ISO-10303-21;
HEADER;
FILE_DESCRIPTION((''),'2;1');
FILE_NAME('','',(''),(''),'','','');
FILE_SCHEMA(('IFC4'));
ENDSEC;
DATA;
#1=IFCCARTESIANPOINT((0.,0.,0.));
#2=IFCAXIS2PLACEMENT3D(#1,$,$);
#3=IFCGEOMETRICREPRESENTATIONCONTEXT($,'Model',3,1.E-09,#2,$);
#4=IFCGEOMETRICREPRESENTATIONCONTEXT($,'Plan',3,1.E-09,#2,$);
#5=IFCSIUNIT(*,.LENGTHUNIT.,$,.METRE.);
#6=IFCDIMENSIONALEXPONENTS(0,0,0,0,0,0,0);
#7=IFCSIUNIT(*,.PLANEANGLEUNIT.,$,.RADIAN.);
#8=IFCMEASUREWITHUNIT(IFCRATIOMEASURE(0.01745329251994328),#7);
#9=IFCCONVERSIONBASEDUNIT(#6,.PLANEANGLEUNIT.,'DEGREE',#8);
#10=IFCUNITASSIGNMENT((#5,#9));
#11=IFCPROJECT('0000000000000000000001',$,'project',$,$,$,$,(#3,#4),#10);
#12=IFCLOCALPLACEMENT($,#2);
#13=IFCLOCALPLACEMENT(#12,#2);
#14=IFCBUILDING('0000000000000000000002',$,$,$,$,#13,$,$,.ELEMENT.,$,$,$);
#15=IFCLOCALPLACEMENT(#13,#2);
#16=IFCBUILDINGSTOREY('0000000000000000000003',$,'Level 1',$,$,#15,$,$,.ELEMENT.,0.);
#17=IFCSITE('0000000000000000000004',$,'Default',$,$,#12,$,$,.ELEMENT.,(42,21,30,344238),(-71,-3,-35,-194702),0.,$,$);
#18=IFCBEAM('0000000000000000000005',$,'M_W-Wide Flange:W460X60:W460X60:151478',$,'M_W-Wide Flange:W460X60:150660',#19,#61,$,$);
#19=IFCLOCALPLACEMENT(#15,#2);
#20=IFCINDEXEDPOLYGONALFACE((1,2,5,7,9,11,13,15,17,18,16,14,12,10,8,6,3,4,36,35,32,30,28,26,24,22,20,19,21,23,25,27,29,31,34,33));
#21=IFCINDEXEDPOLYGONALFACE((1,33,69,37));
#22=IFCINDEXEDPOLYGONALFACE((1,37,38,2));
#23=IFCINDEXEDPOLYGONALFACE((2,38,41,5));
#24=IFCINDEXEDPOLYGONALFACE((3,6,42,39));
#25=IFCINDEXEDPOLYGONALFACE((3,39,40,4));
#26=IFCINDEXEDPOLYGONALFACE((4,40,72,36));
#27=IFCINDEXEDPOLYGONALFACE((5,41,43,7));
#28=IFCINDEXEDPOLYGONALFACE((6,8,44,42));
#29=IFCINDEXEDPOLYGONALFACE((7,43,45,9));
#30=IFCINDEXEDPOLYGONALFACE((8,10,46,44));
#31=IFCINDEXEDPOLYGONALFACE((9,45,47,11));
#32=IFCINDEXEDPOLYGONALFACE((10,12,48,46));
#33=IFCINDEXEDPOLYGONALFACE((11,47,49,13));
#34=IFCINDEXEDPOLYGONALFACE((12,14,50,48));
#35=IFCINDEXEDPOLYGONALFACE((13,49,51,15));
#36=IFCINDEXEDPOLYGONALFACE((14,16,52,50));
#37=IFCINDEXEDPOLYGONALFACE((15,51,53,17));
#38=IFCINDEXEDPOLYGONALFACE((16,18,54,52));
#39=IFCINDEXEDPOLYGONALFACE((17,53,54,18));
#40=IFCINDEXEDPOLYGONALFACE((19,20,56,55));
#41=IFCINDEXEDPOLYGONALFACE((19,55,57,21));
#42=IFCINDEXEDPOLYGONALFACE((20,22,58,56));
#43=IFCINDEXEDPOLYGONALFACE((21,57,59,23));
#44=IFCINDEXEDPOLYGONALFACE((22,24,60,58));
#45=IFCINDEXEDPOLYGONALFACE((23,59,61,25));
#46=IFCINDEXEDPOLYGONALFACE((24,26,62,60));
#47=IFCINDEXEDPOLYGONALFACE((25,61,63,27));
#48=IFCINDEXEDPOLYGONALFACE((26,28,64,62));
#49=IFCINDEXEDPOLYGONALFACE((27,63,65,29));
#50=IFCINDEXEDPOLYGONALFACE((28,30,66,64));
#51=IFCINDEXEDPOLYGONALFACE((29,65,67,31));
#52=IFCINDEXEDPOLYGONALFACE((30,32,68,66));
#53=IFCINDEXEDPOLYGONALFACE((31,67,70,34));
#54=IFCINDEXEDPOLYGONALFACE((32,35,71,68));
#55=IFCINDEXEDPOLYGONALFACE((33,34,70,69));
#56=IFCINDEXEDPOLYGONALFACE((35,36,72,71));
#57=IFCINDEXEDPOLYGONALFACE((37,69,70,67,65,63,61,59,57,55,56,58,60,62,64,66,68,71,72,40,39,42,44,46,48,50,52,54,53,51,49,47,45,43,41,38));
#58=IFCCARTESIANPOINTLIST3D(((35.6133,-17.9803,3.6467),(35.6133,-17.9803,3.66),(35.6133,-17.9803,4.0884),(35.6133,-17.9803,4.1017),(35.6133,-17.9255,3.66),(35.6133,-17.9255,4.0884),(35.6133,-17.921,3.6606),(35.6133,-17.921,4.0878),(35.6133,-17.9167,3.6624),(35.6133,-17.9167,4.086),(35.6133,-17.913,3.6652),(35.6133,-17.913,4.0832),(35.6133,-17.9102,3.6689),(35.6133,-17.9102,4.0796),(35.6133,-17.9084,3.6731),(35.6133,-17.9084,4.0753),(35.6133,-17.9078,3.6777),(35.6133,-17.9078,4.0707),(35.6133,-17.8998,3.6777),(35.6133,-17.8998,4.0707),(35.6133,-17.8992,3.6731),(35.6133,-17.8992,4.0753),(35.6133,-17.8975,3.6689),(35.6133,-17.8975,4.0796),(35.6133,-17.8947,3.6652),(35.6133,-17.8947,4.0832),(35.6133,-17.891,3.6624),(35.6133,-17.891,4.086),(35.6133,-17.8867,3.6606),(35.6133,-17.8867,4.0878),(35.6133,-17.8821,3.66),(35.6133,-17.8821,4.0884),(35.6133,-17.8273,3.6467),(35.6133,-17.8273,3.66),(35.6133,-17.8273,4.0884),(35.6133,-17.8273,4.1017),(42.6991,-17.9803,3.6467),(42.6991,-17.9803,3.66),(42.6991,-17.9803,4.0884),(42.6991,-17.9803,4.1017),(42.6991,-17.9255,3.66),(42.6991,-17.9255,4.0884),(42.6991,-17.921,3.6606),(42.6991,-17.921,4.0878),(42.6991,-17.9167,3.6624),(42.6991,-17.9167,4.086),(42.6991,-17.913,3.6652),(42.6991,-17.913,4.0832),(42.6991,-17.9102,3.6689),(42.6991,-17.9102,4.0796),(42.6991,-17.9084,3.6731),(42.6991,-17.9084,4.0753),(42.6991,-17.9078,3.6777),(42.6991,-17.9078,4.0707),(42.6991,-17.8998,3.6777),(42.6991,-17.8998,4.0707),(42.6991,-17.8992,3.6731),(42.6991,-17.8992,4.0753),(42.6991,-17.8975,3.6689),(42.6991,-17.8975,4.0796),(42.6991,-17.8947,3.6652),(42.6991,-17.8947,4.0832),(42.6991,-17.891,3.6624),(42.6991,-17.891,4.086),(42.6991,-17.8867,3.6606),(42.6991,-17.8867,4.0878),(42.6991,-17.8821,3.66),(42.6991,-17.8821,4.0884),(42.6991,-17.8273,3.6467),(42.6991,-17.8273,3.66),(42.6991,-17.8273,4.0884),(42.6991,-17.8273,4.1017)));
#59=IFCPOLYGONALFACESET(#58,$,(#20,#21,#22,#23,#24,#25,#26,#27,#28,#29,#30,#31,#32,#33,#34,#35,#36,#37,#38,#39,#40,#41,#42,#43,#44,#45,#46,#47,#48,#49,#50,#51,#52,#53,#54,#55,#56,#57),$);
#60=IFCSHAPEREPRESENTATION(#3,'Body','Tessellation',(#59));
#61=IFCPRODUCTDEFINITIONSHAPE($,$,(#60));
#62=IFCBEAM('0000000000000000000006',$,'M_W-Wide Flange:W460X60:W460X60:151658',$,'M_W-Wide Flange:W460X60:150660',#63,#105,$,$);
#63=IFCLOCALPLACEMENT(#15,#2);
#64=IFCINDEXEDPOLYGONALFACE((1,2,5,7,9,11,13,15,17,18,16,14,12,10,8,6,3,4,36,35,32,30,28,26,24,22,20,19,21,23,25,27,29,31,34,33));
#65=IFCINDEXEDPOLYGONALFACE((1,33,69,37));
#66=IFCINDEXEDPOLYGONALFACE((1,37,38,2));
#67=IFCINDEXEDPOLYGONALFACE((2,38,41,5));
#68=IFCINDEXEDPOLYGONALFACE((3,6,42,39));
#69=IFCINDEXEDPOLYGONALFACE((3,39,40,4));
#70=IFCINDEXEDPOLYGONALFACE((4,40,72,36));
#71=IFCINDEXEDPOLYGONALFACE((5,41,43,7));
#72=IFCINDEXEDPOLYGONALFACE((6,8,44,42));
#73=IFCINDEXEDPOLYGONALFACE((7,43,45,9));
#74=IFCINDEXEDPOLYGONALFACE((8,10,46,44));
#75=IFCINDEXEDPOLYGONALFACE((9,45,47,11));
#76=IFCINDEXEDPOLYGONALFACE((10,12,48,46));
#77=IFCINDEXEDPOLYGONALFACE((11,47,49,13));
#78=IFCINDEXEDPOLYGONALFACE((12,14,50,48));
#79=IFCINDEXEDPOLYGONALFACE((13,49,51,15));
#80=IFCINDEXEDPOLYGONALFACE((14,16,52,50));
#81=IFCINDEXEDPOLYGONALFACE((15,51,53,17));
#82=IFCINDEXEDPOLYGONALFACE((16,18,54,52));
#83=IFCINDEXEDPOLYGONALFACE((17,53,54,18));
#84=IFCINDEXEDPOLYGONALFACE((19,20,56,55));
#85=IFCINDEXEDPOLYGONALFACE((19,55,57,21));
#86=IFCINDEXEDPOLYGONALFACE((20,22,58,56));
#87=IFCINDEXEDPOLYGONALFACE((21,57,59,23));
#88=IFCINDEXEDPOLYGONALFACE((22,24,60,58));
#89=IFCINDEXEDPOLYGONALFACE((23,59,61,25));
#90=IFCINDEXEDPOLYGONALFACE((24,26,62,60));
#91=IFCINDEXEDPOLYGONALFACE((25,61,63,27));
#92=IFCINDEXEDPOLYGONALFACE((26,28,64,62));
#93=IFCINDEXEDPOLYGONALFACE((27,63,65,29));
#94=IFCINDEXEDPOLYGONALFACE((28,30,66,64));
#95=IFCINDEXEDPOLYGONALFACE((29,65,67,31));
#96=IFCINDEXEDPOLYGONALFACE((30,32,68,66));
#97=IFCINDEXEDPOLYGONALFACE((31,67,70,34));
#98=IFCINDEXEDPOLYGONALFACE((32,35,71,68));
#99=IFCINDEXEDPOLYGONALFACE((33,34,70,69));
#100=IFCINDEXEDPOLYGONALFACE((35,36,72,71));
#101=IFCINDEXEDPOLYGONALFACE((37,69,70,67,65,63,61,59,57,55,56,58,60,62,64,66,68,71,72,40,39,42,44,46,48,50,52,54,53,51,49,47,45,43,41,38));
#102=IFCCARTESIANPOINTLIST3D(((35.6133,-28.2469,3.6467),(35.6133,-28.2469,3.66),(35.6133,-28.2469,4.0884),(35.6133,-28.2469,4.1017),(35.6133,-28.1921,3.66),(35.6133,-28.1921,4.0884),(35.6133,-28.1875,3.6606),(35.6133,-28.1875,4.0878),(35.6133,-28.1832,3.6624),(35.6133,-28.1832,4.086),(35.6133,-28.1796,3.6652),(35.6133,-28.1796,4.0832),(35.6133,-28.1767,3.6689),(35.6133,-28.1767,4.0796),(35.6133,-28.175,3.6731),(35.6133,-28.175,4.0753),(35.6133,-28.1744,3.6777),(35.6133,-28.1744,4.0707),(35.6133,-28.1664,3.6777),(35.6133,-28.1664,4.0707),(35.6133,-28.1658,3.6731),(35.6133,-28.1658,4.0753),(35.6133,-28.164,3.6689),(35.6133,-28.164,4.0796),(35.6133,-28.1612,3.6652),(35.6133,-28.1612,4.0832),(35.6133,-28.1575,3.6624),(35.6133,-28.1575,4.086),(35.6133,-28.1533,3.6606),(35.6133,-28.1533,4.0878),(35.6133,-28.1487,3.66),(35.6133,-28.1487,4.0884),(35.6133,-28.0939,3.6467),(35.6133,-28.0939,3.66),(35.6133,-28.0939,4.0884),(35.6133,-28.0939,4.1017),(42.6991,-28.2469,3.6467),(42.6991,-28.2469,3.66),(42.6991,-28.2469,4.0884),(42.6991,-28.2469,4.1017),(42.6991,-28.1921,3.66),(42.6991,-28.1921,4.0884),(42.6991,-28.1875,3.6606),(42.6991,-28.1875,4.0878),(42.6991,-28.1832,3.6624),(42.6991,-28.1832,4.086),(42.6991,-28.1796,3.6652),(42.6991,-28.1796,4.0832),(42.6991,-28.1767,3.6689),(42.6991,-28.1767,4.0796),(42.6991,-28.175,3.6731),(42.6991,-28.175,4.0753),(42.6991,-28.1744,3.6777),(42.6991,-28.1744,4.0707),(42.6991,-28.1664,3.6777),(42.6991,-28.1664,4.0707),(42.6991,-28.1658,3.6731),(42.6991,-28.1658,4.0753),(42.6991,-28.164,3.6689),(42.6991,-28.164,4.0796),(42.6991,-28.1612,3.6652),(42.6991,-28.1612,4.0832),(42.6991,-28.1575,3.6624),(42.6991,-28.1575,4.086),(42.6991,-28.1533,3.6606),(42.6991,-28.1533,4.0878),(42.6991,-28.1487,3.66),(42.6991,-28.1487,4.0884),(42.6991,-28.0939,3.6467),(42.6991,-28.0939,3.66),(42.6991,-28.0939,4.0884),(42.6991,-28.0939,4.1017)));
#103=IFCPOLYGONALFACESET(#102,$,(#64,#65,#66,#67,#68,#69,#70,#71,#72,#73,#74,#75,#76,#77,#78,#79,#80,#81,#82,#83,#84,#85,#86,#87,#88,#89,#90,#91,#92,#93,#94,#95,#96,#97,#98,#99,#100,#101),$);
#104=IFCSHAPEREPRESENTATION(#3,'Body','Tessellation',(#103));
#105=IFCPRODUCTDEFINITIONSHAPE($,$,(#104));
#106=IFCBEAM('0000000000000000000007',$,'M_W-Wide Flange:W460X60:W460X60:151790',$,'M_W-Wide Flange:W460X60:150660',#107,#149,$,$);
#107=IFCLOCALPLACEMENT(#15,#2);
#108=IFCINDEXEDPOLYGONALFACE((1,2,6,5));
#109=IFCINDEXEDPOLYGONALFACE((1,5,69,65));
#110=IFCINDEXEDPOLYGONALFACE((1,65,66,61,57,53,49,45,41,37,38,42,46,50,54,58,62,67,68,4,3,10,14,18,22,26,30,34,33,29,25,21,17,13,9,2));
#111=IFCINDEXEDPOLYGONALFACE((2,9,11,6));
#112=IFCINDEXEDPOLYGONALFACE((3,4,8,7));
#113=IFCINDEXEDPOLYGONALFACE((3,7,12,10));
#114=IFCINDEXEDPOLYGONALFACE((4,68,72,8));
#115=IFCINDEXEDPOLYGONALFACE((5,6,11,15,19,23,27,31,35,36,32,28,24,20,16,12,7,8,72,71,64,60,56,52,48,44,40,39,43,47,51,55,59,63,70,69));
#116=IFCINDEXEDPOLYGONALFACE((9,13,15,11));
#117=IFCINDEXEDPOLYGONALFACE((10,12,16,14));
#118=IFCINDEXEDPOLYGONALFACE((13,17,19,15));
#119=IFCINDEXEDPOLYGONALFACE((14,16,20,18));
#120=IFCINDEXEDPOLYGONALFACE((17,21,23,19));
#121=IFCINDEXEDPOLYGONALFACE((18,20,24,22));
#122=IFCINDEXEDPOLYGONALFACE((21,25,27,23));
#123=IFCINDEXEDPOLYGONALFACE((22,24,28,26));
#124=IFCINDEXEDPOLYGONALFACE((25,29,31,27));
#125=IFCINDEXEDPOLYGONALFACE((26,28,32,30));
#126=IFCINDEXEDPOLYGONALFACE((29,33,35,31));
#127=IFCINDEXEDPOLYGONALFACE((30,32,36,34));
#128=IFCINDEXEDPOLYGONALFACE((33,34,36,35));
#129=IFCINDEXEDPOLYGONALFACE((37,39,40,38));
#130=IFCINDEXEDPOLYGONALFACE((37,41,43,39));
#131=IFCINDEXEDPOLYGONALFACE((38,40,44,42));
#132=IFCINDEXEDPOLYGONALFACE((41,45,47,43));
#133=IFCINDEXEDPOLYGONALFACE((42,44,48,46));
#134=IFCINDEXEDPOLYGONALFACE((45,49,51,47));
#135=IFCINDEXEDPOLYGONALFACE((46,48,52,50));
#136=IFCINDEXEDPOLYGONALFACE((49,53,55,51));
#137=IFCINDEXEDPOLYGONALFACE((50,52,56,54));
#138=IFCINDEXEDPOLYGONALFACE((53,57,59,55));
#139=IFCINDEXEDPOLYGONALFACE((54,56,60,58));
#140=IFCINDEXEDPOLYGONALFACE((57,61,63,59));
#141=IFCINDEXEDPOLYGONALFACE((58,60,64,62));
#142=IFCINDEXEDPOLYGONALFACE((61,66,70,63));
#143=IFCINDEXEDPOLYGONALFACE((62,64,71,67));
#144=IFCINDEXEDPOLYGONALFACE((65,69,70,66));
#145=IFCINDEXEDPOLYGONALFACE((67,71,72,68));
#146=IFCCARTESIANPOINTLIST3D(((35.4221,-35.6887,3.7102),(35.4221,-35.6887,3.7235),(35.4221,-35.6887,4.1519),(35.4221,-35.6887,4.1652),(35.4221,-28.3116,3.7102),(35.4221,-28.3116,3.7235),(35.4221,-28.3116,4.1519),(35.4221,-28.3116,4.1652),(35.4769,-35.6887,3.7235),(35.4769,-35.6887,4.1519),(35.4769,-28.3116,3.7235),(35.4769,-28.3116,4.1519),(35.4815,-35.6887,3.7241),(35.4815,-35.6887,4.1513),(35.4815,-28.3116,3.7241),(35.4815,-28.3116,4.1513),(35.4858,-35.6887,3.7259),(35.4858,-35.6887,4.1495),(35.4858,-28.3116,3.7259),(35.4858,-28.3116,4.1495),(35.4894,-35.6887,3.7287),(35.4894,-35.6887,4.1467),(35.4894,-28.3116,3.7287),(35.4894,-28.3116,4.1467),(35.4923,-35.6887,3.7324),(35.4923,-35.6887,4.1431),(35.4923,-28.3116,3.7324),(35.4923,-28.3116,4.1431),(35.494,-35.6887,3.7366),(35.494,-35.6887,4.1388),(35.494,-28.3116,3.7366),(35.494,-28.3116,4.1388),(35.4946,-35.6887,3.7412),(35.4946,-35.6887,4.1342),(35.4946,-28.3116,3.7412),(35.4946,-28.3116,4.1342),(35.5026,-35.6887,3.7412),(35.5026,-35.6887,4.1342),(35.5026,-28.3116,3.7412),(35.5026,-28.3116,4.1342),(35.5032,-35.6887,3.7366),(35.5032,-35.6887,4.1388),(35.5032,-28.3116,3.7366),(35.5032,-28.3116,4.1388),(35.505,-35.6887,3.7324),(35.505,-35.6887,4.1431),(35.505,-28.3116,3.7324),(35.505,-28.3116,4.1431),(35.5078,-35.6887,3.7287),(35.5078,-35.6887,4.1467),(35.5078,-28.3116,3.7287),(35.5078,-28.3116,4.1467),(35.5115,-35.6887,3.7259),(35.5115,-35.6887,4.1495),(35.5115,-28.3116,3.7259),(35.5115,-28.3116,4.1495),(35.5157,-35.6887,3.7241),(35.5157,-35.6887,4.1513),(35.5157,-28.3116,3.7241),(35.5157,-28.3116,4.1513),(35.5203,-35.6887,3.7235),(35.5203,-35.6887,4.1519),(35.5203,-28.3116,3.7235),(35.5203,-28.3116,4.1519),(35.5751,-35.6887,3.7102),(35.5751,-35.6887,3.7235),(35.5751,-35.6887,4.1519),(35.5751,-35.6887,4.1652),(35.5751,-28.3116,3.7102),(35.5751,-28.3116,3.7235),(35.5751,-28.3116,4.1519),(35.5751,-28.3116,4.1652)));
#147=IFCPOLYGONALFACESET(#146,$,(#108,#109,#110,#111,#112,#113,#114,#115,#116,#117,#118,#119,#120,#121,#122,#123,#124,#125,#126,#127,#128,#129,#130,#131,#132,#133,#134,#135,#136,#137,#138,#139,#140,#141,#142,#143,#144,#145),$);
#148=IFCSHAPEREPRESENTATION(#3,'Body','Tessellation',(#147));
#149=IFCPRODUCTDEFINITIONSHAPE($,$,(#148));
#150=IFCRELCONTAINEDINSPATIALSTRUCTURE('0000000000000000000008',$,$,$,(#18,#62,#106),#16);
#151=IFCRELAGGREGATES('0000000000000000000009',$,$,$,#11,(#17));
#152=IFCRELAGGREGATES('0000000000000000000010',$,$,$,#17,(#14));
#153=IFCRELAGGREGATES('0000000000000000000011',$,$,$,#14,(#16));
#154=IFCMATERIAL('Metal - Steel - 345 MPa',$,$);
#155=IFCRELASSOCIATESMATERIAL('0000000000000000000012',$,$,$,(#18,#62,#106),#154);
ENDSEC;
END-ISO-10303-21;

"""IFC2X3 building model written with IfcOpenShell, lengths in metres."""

from ifc_helpers import new_model, entity, si_unit, converted_unit, frame, frame_2d, origin, place, context, project, spatial, polyline, circle_curve, parameter, trimmed, segment, composite_curve, outline, extrude, material, element, save


model = new_model("IFC2X3")

# Units and contexts
model_context = context("Model", 3, precision=1e-09, world=origin())
plan_context = context("Plan", 3, precision=1e-09, world=origin())
ifc_project = project(units=[si_unit("LENGTHUNIT", "METRE"), converted_unit("PLANEANGLEUNIT", "DEGREE", entity("IfcRatioMeasure", 0.01745329251994328), si_unit("PLANEANGLEUNIT", "RADIAN"), dimensions=[0, 0, 0, 0, 0, 0, 0])], contexts=[model_context, plan_context])

# Site, building, storey
site_placement = place(None, origin())
site = spatial("IfcSite", under=ifc_project, at=site_placement, Name="Default", CompositionType="ELEMENT", RefLatitude=(42, 21, 30, 344238), RefLongitude=(-71, -3, -35, -194702), RefElevation=0.0)
building_placement = place(site_placement, origin())
building = spatial("IfcBuilding", under=site, at=building_placement, CompositionType="ELEMENT")
storey_placement = place(building_placement, origin())
storey = spatial("IfcBuildingStorey", under=building, at=storey_placement, Name="Level 1", CompositionType="ELEMENT", Elevation=0.0)

# Beams
ifc_material = material(Name="Metal - Steel - 345 MPa")
beam_1_placement = place(storey_placement, frame((42.8138, -17.9038, 4.2672), z_axis=(0.0, 0.0, 1.0), x_axis=(0.0, 1.0, 0.0)))
element("IfcBeam", 1, at=beam_1_placement, inside=storey, material=ifc_material, Name="M_W-Wide Flange:W460X60:W460X60:151478", ObjectType="M_W-Wide Flange:W460X60:150660", context=model_context, shape_type="SweptSolid", body=[
    extrude(outline(composite_curve([segment(polyline([(0.2142, -0.0765), (0.2275, -0.0765)]), True, "CONTINUOUS"), segment(polyline([(0.2275, -0.0765), (0.2275, 0.0765)]), True, "CONTINUOUS"), segment(polyline([(0.2275, 0.0765), (0.2142, 0.0765)]), True, "CONTINUOUS"), segment(polyline([(0.2142, 0.0765), (0.2142, 0.0217)]), True, "CONTINUOUS"), segment(trimmed(circle_curve(frame_2d((0.1965, 0.0217), x_axis=(1.0, 0.0)), 0.0177), [parameter(270.0)], [parameter(360.0)], True, "PARAMETER"), False, "CONTINUOUS"), segment(polyline([(0.1965, 0.004), (-0.1965, 0.004)]), True, "CONTINUOUS"), segment(trimmed(circle_curve(frame_2d((-0.1965, 0.0217), x_axis=(0.0, -1.0)), 0.0177), [parameter(270.0)], [parameter(360.0)], True, "PARAMETER"), False, "CONTINUOUS"), segment(polyline([(-0.2142, 0.0217), (-0.2142, 0.0765)]), True, "CONTINUOUS"), segment(polyline([(-0.2142, 0.0765), (-0.2275, 0.0765)]), True, "CONTINUOUS"), segment(polyline([(-0.2275, 0.0765), (-0.2275, -0.0765)]), True, "CONTINUOUS"), segment(polyline([(-0.2275, -0.0765), (-0.2142, -0.0765)]), True, "CONTINUOUS"), segment(polyline([(-0.2142, -0.0765), (-0.2142, -0.0217)]), True, "CONTINUOUS"), segment(trimmed(circle_curve(frame_2d((-0.1965, -0.0217), x_axis=(-1.0, 0.0)), 0.0177), [parameter(270.0)], [parameter(360.0)], True, "PARAMETER"), False, "CONTINUOUS"), segment(polyline([(-0.1965, -0.004), (0.1965, -0.004)]), True, "CONTINUOUS"), segment(trimmed(circle_curve(frame_2d((0.1965, -0.0217), x_axis=(0.0, 1.0)), 0.0177), [parameter(270.0)], [parameter(0.0)], True, "PARAMETER"), False, "CONTINUOUS"), segment(polyline([(0.2142, -0.0217), (0.2142, -0.0765)]), True, "CONTINUOUS")], self_intersect=False)), frame((0.0, 7.2005, -0.393), z_axis=(0.0, -1.0, 0.0), x_axis=(0.0, 0.0, -1.0)), (0.0, 0.0, 1.0), 7.0858),
])
beam_2_placement = place(storey_placement, frame((35.4986, -28.1704, 4.2672), z_axis=(0.0, 0.0, 1.0), x_axis=(0.0, -1.0, 0.0)))
element("IfcBeam", 2, at=beam_2_placement, inside=storey, material=ifc_material, Name="M_W-Wide Flange:W460X60:W460X60:151658", ObjectType="M_W-Wide Flange:W460X60:150660", context=model_context, shape_type="SweptSolid", body=[
    extrude(outline(composite_curve([segment(polyline([(-0.0765, -0.2142), (-0.0765, -0.2275)]), True, "CONTINUOUS"), segment(polyline([(-0.0765, -0.2275), (0.0765, -0.2275)]), True, "CONTINUOUS"), segment(polyline([(0.0765, -0.2275), (0.0765, -0.2142)]), True, "CONTINUOUS"), segment(polyline([(0.0765, -0.2142), (0.0217, -0.2142)]), True, "CONTINUOUS"), segment(trimmed(circle_curve(frame_2d((0.0217, -0.1965), x_axis=(0.0, -1.0)), 0.0177), [parameter(270.0)], [parameter(360.0)], True, "PARAMETER"), False, "CONTINUOUS"), segment(polyline([(0.004, -0.1965), (0.004, 0.1965)]), True, "CONTINUOUS"), segment(trimmed(circle_curve(frame_2d((0.0217, 0.1965), x_axis=(-1.0, 0.0)), 0.0177), [parameter(270.0)], [parameter(360.0)], True, "PARAMETER"), False, "CONTINUOUS"), segment(polyline([(0.0217, 0.2142), (0.0765, 0.2142)]), True, "CONTINUOUS"), segment(polyline([(0.0765, 0.2142), (0.0765, 0.2275)]), True, "CONTINUOUS"), segment(polyline([(0.0765, 0.2275), (-0.0765, 0.2275)]), True, "CONTINUOUS"), segment(polyline([(-0.0765, 0.2275), (-0.0765, 0.2142)]), True, "CONTINUOUS"), segment(polyline([(-0.0765, 0.2142), (-0.0217, 0.2142)]), True, "CONTINUOUS"), segment(trimmed(circle_curve(frame_2d((-0.0217, 0.1965), x_axis=(0.0, 1.0)), 0.0177), [parameter(270.0)], [parameter(360.0)], True, "PARAMETER"), False, "CONTINUOUS"), segment(polyline([(-0.004, 0.1965), (-0.004, -0.1965)]), True, "CONTINUOUS"), segment(trimmed(circle_curve(frame_2d((-0.0217, -0.1965), x_axis=(1.0, 0.0)), 0.0177), [parameter(270.0)], [parameter(0.0)], True, "PARAMETER"), False, "CONTINUOUS"), segment(polyline([(-0.0217, -0.2142), (-0.0765, -0.2142)]), True, "CONTINUOUS")], self_intersect=False)), frame((0.0, 0.1147, -0.393), z_axis=(0.0, -1.0, 0.0), x_axis=(1.0, 0.0, 0.0)), (0.0, 0.0, -1.0), 7.0858),
])
beam_3_placement = place(storey_placement, frame((35.4986, -35.8299, 4.2672)))
element("IfcBeam", 3, at=beam_3_placement, inside=storey, material=ifc_material, Name="M_W-Wide Flange:W460X60:W460X60:151790", ObjectType="M_W-Wide Flange:W460X60:150660", context=model_context, shape_type="SweptSolid", body=[
    extrude(outline(composite_curve([segment(polyline([(-0.0765, -0.2142), (-0.0765, -0.2275)]), True, "CONTINUOUS"), segment(polyline([(-0.0765, -0.2275), (0.0765, -0.2275)]), True, "CONTINUOUS"), segment(polyline([(0.0765, -0.2275), (0.0765, -0.2142)]), True, "CONTINUOUS"), segment(polyline([(0.0765, -0.2142), (0.0217, -0.2142)]), True, "CONTINUOUS"), segment(trimmed(circle_curve(frame_2d((0.0217, -0.1965), x_axis=(0.0, -1.0)), 0.0177), [parameter(270.0)], [parameter(360.0)], True, "PARAMETER"), False, "CONTINUOUS"), segment(polyline([(0.004, -0.1965), (0.004, 0.1965)]), True, "CONTINUOUS"), segment(trimmed(circle_curve(frame_2d((0.0217, 0.1965), x_axis=(-1.0, 0.0)), 0.0177), [parameter(270.0)], [parameter(360.0)], True, "PARAMETER"), False, "CONTINUOUS"), segment(polyline([(0.0217, 0.2142), (0.0765, 0.2142)]), True, "CONTINUOUS"), segment(polyline([(0.0765, 0.2142), (0.0765, 0.2275)]), True, "CONTINUOUS"), segment(polyline([(0.0765, 0.2275), (-0.0765, 0.2275)]), True, "CONTINUOUS"), segment(polyline([(-0.0765, 0.2275), (-0.0765, 0.2142)]), True, "CONTINUOUS"), segment(polyline([(-0.0765, 0.2142), (-0.0217, 0.2142)]), True, "CONTINUOUS"), segment(trimmed(circle_curve(frame_2d((-0.0217, 0.1965), x_axis=(0.0, 1.0)), 0.0177), [parameter(270.0)], [parameter(360.0)], True, "PARAMETER"), False, "CONTINUOUS"), segment(polyline([(-0.004, 0.1965), (-0.004, -0.1965)]), True, "CONTINUOUS"), segment(trimmed(circle_curve(frame_2d((-0.0217, -0.1965), x_axis=(1.0, 0.0)), 0.0177), [parameter(270.0)], [parameter(0.0)], True, "PARAMETER"), False, "CONTINUOUS"), segment(polyline([(-0.0217, -0.2142), (-0.0765, -0.2142)]), True, "CONTINUOUS")], self_intersect=False)), frame((0.0, 0.1412, -0.3295), z_axis=(0.0, -1.0, 0.0), x_axis=(1.0, 0.0, 0.0)), (0.0, 0.0, -1.0), 7.3771),
])

save(model, "model.ifc")
